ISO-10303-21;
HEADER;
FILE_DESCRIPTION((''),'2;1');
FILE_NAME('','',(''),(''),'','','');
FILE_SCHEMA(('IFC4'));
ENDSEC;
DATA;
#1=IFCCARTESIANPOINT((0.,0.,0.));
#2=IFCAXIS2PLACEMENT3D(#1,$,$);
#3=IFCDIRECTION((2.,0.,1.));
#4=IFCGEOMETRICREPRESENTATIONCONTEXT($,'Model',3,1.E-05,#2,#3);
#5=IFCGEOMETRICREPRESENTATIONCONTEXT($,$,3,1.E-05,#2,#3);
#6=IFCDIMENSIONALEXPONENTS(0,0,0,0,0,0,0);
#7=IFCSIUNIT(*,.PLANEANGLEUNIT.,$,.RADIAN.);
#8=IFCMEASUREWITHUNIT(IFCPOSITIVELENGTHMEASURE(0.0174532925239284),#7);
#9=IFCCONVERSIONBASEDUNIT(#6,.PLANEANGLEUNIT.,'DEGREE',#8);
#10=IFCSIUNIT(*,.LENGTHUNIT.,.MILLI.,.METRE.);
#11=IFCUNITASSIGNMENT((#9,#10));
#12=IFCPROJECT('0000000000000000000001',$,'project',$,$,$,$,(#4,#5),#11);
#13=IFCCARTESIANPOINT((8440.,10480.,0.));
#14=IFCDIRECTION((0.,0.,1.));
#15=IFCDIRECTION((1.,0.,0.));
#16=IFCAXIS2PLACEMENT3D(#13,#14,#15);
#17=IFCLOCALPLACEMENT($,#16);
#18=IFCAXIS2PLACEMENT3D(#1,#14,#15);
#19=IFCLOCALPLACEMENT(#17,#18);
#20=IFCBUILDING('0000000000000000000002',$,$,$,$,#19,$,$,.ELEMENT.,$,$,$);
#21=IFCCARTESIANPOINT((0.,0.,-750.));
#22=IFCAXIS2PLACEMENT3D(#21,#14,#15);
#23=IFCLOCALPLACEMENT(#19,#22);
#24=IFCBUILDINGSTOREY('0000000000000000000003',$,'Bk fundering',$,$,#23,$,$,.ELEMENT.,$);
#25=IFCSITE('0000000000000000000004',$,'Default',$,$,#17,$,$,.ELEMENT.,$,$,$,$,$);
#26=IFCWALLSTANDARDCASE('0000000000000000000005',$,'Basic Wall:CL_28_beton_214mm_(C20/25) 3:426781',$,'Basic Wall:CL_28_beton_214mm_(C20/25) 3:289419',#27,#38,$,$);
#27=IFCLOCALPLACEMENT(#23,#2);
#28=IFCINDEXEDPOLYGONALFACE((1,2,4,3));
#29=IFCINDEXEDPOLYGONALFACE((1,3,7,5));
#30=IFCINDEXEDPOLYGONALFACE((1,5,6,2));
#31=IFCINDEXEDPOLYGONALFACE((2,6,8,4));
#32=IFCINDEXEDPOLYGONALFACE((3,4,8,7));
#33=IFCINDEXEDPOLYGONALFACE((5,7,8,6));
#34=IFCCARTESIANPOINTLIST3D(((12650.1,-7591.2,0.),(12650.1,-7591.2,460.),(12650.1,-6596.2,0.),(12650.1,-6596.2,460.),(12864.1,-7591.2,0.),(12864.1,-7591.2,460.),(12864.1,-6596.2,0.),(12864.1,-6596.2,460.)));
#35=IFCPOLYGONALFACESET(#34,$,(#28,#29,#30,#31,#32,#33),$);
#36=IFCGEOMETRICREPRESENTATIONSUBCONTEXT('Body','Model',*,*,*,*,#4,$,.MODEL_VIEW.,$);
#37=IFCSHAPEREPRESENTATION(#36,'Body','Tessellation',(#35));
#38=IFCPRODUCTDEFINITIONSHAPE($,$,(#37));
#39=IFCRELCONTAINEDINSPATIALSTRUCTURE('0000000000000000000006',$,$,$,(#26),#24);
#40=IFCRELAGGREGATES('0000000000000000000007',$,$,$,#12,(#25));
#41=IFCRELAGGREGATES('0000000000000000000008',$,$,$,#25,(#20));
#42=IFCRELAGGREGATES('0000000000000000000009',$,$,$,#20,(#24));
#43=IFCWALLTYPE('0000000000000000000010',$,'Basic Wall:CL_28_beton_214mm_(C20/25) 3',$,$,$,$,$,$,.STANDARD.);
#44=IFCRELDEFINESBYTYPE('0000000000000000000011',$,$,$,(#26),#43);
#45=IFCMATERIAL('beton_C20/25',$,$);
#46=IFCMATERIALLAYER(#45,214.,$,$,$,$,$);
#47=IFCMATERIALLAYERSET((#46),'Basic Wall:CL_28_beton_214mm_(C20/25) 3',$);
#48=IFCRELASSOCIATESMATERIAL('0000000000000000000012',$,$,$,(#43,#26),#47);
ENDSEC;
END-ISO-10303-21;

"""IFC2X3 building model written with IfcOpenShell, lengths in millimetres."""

from ifc_helpers import new_model, entity, si_unit, converted_unit, direction, frame, frame_2d, origin, origin_with_axes, place, context, subcontext, project, spatial, polyline, rectangle, extrude, clip, bounded_halfspace, material, layer, layer_set, layer_usage, type_object, element, save


model = new_model("IFC2X3")

# Units and contexts
model_context = context("Model", 3, precision=1e-05, world=origin(), true_north=direction((2.0, 0.0, 1.0)))
context_of_model = context(None, 3, precision=1e-05, world=origin(), true_north=direction((2.0, 0.0, 1.0)))
body_context = subcontext(model_context, "Body", "Model", "MODEL_VIEW")
ifc_project = project(units=[converted_unit("PLANEANGLEUNIT", "DEGREE", entity("IfcPositiveLengthMeasure", 0.0174532925239284), si_unit("PLANEANGLEUNIT", "RADIAN"), dimensions=[0, 0, 0, 0, 0, 0, 0]), si_unit("LENGTHUNIT", "METRE", prefix="MILLI")], contexts=[model_context, context_of_model])

# Site, building, storey
site_placement = place(None, frame((8440.0, 10480.0, 0.0), z_axis=(0.0, 0.0, 1.0), x_axis=(1.0, 0.0, 0.0)))
site = spatial("IfcSite", under=ifc_project, at=site_placement, Name="Default", CompositionType="ELEMENT")
building_placement = place(site_placement, origin_with_axes())
building = spatial("IfcBuilding", under=site, at=building_placement, CompositionType="ELEMENT")
storey_placement = place(building_placement, frame((0.0, 0.0, -750.0), z_axis=(0.0, 0.0, 1.0), x_axis=(1.0, 0.0, 0.0)))
storey = spatial("IfcBuildingStorey", under=building, at=storey_placement, Name="Bk fundering", CompositionType="ELEMENT")

# Wall
ifc_material_1 = material(Name="beton_C20/25")
ifc_layer_1 = layer(ifc_material_1, 214.0)
ifc_layer_set_1 = layer_set([ifc_layer_1], Name="Basic Wall:CL_28_beton_214mm_(C20/25) 3")
wall_type_1 = type_object("IfcWallType", Name="Basic Wall:CL_28_beton_214mm_(C20/25) 3", PredefinedType="STANDARD", material=ifc_layer_set_1)
ifc_layer_usage_1 = layer_usage(ifc_layer_set_1, "AXIS2", "NEGATIVE", 107.0)
wall_1_placement = place(storey_placement, frame((12757.1, -7591.2, 0.0), z_axis=(0.0, 0.0, 1.0), x_axis=(0.0, 1.0, 0.0)))
element("IfcWallStandardCase", 1, at=wall_1_placement, inside=storey, type_object=wall_type_1, material=ifc_layer_usage_1, Name="Basic Wall:CL_28_beton_214mm_(C20/25) 3:426781", ObjectType="Basic Wall:CL_28_beton_214mm_(C20/25) 3:289419", context=body_context, shape_type="Clipping", body=[
    clip(extrude(rectangle(XDim=995.0, YDim=214.0, at=frame_2d((497.5, 0.0), x_axis=(-1.0, 0.0))), origin(), (0.0, 0.0, 1.0), 460.0), bounded_halfspace(frame((0.0, -107.0, 460.0), z_axis=(0.0, 0.0, -1.0), x_axis=(-1.0, 0.0, 0.0)), True, frame((0.0, -107.0, 460.0)), polyline([(0.0, 0.0), (995.0, 0.0), (995.0, 214.0), (0.0, 214.0), (0.0, 0.0)]))),
])

save(model, "model.ifc")
